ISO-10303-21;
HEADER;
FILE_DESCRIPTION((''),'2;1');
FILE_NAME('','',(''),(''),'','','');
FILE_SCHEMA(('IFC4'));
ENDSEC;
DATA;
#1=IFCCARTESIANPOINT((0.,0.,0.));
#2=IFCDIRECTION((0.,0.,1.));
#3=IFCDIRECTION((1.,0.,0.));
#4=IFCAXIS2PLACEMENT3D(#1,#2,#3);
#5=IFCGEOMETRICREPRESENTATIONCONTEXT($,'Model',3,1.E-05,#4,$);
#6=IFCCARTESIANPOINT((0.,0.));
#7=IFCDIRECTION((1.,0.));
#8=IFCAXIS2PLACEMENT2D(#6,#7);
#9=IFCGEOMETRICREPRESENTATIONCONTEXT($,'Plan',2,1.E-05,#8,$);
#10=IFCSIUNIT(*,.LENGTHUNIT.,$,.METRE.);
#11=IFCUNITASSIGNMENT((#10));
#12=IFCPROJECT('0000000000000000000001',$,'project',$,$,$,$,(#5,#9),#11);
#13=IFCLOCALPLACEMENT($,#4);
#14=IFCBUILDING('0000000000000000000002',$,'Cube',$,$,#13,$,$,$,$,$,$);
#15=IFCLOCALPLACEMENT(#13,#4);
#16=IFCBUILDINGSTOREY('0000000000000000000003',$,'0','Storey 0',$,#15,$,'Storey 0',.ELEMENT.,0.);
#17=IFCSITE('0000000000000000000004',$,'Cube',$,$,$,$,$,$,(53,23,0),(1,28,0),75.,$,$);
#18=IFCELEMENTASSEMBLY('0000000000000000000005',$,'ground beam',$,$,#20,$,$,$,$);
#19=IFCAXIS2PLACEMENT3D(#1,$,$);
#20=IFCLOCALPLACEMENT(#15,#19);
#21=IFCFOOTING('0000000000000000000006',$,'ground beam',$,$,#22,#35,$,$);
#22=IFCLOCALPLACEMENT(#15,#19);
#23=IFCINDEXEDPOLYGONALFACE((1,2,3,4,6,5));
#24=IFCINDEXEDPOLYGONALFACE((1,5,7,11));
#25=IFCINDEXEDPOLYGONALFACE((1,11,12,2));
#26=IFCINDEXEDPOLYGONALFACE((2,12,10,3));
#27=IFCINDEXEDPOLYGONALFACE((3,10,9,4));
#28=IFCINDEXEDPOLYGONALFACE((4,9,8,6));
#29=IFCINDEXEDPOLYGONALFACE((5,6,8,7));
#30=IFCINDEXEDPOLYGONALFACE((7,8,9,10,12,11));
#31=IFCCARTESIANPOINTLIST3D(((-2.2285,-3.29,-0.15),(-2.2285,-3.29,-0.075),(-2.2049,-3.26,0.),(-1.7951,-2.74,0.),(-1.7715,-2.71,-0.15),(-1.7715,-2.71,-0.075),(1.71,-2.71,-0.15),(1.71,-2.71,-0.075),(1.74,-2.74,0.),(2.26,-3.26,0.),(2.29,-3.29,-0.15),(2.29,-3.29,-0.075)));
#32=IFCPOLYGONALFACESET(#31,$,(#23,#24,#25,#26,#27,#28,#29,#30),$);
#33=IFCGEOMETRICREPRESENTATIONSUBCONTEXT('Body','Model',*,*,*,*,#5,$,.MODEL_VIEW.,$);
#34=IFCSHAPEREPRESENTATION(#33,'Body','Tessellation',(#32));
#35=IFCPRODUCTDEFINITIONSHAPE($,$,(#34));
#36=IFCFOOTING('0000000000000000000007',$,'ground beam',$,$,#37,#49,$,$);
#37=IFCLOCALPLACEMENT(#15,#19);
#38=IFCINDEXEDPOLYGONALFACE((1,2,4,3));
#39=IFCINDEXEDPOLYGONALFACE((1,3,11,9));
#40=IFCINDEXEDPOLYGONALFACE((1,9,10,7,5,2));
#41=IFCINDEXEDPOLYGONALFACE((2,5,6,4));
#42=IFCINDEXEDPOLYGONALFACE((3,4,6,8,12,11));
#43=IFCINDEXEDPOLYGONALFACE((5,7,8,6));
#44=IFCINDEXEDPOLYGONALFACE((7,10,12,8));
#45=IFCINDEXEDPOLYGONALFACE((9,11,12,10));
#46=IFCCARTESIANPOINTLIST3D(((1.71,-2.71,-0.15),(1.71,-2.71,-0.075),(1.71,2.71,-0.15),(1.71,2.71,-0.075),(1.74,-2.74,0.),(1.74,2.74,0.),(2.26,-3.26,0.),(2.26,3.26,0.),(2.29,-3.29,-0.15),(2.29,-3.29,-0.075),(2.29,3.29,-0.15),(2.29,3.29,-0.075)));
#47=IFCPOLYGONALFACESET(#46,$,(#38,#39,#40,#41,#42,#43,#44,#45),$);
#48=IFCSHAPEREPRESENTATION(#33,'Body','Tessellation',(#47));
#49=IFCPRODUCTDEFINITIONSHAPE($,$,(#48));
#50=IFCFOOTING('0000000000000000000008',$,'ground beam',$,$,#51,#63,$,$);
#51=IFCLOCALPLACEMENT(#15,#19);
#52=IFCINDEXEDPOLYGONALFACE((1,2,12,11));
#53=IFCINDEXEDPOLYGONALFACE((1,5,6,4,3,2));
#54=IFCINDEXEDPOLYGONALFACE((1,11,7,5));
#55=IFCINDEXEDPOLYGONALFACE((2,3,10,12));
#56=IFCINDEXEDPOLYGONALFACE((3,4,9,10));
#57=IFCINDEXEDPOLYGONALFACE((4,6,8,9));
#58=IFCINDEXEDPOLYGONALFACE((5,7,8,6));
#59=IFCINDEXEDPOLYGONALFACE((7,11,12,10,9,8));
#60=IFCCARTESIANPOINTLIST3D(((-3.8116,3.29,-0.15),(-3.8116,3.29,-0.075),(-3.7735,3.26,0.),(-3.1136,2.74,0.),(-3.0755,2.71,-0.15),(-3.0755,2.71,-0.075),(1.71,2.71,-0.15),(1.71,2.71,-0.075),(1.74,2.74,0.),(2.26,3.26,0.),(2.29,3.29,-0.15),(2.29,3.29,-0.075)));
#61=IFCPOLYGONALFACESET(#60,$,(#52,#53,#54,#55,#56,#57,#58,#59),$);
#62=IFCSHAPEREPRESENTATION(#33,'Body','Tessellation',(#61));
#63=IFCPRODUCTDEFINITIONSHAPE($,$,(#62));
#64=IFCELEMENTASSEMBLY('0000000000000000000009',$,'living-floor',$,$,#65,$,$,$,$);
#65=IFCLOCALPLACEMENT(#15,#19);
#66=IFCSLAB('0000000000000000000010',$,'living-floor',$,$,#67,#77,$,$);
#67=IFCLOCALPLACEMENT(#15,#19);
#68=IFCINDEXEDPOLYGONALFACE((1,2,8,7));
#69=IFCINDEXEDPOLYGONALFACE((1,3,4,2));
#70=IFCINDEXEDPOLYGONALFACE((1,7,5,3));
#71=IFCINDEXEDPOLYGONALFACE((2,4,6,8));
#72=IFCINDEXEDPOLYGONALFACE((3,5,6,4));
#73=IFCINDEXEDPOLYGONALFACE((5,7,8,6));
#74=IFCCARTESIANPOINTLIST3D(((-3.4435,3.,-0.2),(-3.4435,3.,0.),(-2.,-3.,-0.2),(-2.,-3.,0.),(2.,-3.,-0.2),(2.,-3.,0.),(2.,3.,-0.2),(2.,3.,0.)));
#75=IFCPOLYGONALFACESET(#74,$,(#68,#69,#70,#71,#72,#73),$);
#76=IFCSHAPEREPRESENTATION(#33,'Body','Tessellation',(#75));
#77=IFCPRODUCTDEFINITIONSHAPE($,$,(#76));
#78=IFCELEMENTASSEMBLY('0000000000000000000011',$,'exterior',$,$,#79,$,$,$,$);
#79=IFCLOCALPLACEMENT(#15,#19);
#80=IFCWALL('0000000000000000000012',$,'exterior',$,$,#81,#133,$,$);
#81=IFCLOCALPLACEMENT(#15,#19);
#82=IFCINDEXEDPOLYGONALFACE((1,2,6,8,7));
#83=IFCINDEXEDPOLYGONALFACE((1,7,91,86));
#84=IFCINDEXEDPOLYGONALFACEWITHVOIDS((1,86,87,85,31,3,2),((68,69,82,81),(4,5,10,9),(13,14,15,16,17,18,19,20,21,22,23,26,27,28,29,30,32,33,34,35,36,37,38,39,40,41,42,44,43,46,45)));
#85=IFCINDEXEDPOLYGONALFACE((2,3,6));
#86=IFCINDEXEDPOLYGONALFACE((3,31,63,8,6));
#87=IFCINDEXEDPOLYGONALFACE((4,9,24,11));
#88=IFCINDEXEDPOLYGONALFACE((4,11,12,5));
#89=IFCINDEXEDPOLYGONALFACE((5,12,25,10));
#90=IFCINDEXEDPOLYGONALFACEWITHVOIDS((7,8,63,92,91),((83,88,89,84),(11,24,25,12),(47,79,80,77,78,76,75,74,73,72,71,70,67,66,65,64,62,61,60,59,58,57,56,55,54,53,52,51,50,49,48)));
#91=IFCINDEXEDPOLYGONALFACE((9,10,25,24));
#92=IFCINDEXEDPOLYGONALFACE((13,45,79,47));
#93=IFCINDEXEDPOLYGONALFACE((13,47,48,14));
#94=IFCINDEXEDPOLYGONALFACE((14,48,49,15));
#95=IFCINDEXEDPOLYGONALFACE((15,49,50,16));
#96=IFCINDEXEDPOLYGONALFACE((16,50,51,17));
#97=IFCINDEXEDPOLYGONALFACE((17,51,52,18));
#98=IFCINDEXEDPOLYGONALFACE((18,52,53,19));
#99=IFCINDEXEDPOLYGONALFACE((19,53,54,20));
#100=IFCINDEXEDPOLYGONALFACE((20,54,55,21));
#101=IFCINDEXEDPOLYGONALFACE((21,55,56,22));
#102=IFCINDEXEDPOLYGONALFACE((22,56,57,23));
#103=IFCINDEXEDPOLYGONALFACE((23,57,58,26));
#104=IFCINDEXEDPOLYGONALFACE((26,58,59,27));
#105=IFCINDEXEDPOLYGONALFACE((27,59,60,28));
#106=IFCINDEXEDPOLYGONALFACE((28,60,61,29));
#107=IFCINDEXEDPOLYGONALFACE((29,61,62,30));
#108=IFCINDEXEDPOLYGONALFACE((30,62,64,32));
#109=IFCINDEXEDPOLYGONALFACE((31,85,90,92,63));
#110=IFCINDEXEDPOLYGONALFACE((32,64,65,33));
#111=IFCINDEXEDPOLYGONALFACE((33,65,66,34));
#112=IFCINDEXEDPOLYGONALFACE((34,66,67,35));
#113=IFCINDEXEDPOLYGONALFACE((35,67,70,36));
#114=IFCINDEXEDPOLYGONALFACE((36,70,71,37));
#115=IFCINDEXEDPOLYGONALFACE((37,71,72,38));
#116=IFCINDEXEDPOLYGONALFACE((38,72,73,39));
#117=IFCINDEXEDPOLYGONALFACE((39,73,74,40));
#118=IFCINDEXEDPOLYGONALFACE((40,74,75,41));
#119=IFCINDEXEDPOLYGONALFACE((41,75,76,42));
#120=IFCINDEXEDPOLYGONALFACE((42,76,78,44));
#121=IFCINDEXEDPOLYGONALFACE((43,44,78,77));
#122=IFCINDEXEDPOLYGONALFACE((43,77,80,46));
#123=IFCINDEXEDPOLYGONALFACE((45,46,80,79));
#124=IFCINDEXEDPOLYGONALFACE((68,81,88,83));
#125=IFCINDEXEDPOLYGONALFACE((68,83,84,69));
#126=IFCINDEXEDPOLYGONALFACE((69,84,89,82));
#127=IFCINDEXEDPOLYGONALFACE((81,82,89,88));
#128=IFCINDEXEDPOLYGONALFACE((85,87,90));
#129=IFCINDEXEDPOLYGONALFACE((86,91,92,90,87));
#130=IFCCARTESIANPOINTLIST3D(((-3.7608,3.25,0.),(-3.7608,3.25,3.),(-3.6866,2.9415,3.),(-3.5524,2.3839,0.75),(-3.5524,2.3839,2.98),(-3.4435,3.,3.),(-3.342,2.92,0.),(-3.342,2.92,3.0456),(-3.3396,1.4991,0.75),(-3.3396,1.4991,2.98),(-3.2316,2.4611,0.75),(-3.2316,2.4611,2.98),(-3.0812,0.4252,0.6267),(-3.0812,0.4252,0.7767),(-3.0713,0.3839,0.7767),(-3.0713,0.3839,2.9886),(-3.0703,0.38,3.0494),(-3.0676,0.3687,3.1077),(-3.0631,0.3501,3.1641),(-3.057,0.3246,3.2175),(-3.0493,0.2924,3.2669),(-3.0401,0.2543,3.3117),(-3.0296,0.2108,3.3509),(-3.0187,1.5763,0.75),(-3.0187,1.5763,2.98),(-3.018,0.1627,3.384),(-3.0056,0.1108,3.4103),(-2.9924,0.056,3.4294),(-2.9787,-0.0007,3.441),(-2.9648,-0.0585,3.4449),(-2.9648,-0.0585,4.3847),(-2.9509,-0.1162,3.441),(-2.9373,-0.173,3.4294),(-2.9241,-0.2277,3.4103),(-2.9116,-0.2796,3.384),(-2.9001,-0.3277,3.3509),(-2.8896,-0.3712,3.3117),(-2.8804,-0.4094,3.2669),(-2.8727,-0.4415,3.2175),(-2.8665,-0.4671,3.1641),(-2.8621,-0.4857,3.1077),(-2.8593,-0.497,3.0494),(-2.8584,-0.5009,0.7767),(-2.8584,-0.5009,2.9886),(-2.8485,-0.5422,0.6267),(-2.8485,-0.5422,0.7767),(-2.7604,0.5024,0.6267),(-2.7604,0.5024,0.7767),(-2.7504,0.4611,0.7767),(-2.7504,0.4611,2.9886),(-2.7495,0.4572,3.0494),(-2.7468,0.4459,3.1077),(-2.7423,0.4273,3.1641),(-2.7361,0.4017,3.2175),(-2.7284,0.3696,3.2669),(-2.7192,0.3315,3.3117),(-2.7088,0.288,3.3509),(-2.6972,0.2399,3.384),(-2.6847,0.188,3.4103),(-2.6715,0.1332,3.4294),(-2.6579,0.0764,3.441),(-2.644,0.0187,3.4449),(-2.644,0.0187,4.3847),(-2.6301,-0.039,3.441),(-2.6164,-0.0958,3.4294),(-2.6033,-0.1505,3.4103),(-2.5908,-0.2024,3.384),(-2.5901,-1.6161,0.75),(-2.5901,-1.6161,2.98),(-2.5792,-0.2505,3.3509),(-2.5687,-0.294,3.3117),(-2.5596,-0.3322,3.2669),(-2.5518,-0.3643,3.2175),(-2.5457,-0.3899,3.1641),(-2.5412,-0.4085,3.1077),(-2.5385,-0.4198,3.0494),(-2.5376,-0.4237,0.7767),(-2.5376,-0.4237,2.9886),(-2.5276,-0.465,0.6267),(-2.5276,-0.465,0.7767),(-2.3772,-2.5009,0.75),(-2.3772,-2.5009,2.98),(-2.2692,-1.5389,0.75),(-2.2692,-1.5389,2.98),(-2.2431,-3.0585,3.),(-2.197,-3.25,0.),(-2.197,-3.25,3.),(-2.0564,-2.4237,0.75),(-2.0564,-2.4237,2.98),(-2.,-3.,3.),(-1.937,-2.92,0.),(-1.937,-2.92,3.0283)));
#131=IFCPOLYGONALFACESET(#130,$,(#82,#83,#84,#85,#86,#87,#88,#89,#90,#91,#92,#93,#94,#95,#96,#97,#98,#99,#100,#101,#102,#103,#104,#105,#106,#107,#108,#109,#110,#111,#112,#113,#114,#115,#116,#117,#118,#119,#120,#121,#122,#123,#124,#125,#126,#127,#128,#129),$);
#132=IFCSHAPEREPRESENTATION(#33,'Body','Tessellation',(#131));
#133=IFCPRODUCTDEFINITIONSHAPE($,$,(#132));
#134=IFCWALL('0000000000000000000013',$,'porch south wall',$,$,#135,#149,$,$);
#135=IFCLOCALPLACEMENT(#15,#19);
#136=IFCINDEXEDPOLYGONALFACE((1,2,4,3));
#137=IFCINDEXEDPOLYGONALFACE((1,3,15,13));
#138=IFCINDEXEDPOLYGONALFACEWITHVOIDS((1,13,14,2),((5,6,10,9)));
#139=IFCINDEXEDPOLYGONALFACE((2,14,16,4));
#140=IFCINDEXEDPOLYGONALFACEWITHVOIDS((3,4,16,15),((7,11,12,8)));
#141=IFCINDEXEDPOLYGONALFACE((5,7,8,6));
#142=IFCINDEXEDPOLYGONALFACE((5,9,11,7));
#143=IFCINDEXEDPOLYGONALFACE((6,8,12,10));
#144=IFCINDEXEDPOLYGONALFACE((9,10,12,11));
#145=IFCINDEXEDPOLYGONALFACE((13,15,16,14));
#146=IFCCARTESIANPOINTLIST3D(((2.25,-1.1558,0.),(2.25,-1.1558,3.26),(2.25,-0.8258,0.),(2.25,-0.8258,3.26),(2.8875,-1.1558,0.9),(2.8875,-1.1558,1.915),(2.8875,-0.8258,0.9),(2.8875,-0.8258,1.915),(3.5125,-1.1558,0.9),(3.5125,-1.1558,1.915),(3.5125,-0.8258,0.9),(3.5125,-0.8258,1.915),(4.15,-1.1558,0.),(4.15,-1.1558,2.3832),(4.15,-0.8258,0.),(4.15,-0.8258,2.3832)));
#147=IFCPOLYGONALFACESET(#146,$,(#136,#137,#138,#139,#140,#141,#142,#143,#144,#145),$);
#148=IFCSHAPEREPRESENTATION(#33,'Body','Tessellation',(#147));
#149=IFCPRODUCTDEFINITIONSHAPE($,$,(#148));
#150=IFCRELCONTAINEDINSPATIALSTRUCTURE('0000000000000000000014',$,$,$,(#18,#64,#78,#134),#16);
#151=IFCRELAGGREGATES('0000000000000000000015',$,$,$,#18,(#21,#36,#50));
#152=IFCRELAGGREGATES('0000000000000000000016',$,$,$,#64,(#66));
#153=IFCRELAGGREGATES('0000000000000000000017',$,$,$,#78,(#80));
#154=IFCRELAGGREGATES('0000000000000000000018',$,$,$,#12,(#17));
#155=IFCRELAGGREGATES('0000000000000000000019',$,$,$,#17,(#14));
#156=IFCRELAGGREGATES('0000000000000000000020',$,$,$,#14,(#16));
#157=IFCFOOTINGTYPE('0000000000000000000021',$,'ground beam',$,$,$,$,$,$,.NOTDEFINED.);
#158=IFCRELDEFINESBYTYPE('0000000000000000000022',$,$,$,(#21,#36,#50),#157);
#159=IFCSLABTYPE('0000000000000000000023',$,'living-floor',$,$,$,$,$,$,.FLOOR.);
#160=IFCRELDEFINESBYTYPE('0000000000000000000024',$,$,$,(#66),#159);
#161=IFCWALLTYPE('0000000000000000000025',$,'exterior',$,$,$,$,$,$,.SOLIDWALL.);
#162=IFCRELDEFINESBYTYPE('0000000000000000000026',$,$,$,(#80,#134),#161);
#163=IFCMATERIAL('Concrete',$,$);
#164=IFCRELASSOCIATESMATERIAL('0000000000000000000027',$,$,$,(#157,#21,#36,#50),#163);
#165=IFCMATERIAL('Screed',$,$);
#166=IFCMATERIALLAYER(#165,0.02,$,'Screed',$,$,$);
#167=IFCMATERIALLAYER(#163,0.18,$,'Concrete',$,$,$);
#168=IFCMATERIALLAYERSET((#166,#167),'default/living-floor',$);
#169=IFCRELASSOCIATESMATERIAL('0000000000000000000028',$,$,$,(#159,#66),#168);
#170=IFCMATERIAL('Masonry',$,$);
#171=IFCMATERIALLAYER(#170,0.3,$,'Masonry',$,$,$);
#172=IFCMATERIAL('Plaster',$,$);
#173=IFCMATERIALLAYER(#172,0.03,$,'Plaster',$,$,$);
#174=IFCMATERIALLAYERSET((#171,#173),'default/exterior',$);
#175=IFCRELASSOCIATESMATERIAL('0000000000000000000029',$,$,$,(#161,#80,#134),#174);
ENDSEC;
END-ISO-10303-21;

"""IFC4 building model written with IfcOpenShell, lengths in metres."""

from ifc_helpers import new_model, si_unit, frame, origin, origin_with_axes, origin_2d_with_axis, place, context, subcontext, project, spatial, polyline, indexed_curve, outline, extrude, clip, halfspace, bounded_halfspace, material, layer, layer_set, layer_usage, material_profile, profile_set, profile_usage, type_object, element, aggregate, save


model = new_model("IFC4")

# Units and contexts
model_context = context("Model", 3, precision=1e-05, world=origin_with_axes())
plan_context = context("Plan", 2, precision=1e-05, world=origin_2d_with_axis())
body_context_1 = subcontext(model_context, "Body", "Model", "MODEL_VIEW")
ifc_project = project(units=[si_unit("LENGTHUNIT", "METRE")], contexts=[model_context, plan_context])

# Site, building, storey
site = spatial("IfcSite", under=ifc_project, Name="Cube", RefLatitude=(53, 23, 0), RefLongitude=(1, 28, 0), RefElevation=75.0)
building_placement = place(None, origin_with_axes())
building = spatial("IfcBuilding", under=site, at=building_placement, Name="Cube")
storey_placement = place(building_placement, origin_with_axes())
storey = spatial("IfcBuildingStorey", under=building, at=storey_placement, Name="0", Description="Storey 0", LongName="Storey 0", CompositionType="ELEMENT", Elevation=0.0)

# Element assembly, footings
assembly_1_placement = place(storey_placement, origin_with_axes())
assembly_1 = element("IfcElementAssembly", 1, at=assembly_1_placement, inside=storey, Name="ground beam")
ifc_material_1 = material(Name="Concrete")
ifc_material_profile = material_profile(ifc_material_1, outline(polyline([(-0.26, 0.0), (-0.29, -0.075), (-0.29, -0.15), (0.29, -0.15), (0.29, -0.075), (0.26, 0.0), (-0.26, 0.0)])))
ifc_profile_set = profile_set([ifc_material_profile])
ifc_profile_usage_1 = profile_usage(ifc_profile_set)
footing_type = type_object("IfcFootingType", Name="ground beam", PredefinedType="NOTDEFINED", material=ifc_profile_set)
footing_1_placement = place(assembly_1_placement, frame((3.0, -3.0, 0.0), z_axis=(-1.0, 0.0, 0.0), x_axis=(0.0, -1.0, 0.0)))
footing_1 = element("IfcFooting", 2, at=footing_1_placement, type_object=footing_type, material=ifc_profile_usage_1, Name="ground beam", context=body_context_1, shape_type="Clipping", body=[
    clip(clip(extrude(outline(polyline([(-0.26, 0.0), (-0.29, -0.075), (-0.29, -0.15), (0.29, -0.15), (0.29, -0.075), (0.26, 0.0), (-0.26, 0.0)])), origin_with_axes(), (0.0, 0.0, 1.0), 6.0), halfspace(frame((0.0, 0.0, 1.0), z_axis=(-0.707107, 0.0, -0.707107), x_axis=(0.0, 1.0, 0.0)), False)), halfspace(frame((0.0, 0.0, 5.0), z_axis=(-0.618904, 0.0, 0.785467), x_axis=(0.0, 1.0, 0.0)), False)),
])
ifc_profile_usage_2 = profile_usage(ifc_profile_set)
footing_2_placement = place(assembly_1_placement, frame((2.0, 4.0, 0.0), z_axis=(0.0, -1.0, 0.0), x_axis=(1.0, 0.0, 0.0)))
footing_2 = element("IfcFooting", 3, at=footing_2_placement, type_object=footing_type, material=ifc_profile_usage_2, Name="ground beam", context=body_context_1, shape_type="Clipping", body=[
    clip(clip(extrude(outline(polyline([(-0.26, 0.0), (-0.29, -0.075), (-0.29, -0.15), (0.29, -0.15), (0.29, -0.075), (0.26, 0.0), (-0.26, 0.0)])), origin_with_axes(), (0.0, 0.0, 1.0), 8.0), halfspace(frame((0.0, 0.0, 1.0), z_axis=(-0.707107, 0.0, -0.707107), x_axis=(0.0, 1.0, 0.0)), False)), halfspace(frame((0.0, 0.0, 7.0), z_axis=(-0.707107, 0.0, 0.707107), x_axis=(0.0, 1.0, 0.0)), False)),
])
ifc_profile_usage_3 = profile_usage(ifc_profile_set)
footing_3_placement = place(assembly_1_placement, frame((-4.4435, 3.0, 0.0), z_axis=(1.0, 0.0, 0.0), x_axis=(0.0, 1.0, 0.0)))
footing_3 = element("IfcFooting", 4, at=footing_3_placement, type_object=footing_type, material=ifc_profile_usage_3, Name="ground beam", context=body_context_1, shape_type="Clipping", body=[
    clip(clip(extrude(outline(polyline([(-0.26, 0.0), (-0.29, -0.075), (-0.29, -0.15), (0.29, -0.15), (0.29, -0.075), (0.26, 0.0), (-0.26, 0.0)])), origin_with_axes(), (0.0, 0.0, 1.0), 7.4435), halfspace(frame((0.0, 0.0, 1.0), z_axis=(-0.785467, 0.0, -0.618904), x_axis=(0.0, 1.0, 0.0)), False)), halfspace(frame((0.0, 0.0, 6.4435), z_axis=(-0.707107, 0.0, 0.707107), x_axis=(0.0, 1.0, 0.0)), False)),
])
aggregate(assembly_1, [footing_1, footing_2, footing_3])

# Element assembly, slab
assembly_2_placement = place(storey_placement, origin_with_axes())
assembly_2 = element("IfcElementAssembly", 5, at=assembly_2_placement, inside=storey, Name="living-floor")
ifc_material_2 = material(Name="Screed")
ifc_layer_1 = layer(ifc_material_2, 0.02, Name="Screed")
ifc_layer_2 = layer(ifc_material_1, 0.18, Name="Concrete")
ifc_layer_set_1 = layer_set([ifc_layer_1, ifc_layer_2], Name="default/living-floor")
ifc_layer_usage_1 = layer_usage(ifc_layer_set_1, "AXIS3", "POSITIVE", 0.0)
slab_type = type_object("IfcSlabType", Name="living-floor", PredefinedType="FLOOR", material=ifc_layer_set_1)
slab_placement = place(assembly_2_placement, frame((2.0, 3.0, -0.2), z_axis=(0.0, 0.0, -1.0), x_axis=(0.0, 1.0, 0.0)))
slab = element("IfcSlab", 6, at=slab_placement, type_object=slab_type, material=ifc_layer_usage_1, Name="living-floor", context=body_context_1, shape_type="SweptSolid", body=[
    extrude(outline(polyline([(0.0, 0.0), (-6.0, 0.0), (-6.0, -4.0), (0.0, -5.4435), (0.0, 0.0)])), origin(), (0.0, 0.0, -1.0), 0.2),
])
aggregate(assembly_2, [slab])

# Element assembly, wall, openings
assembly_3_placement = place(storey_placement, frame((-3.4435, 3.0, 0.0), z_axis=(0.0, 0.0, 1.0), x_axis=(0.233915, -0.972257, 0.0)))
assembly_3 = element("IfcElementAssembly", 7, at=assembly_3_placement, inside=storey, Name="exterior")
ifc_material_3 = material(Name="Masonry")
ifc_layer_3 = layer(ifc_material_3, 0.3, Name="Masonry")
ifc_material_4 = material(Name="Plaster")
ifc_layer_4 = layer(ifc_material_4, 0.03, Name="Plaster")
ifc_layer_set_2 = layer_set([ifc_layer_3, ifc_layer_4], Name="default/exterior")
ifc_layer_usage_2 = layer_usage(ifc_layer_set_2, "AXIS2", "POSITIVE", -0.25)
wall_type = type_object("IfcWallType", Name="exterior", PredefinedType="SOLIDWALL", material=ifc_layer_set_2)
wall_1_placement = place(assembly_3_placement, frame((0.0, 0.0, 0.0), z_axis=(0.0, 0.0, 1.0), x_axis=(1.0, 0.0, 0.0)))
wall_1 = element("IfcWall", 8, at=wall_1_placement, type_object=wall_type, material=ifc_layer_usage_2, Name="exterior", context=body_context_1, shape_type="Clipping", body=[
    clip(clip(clip(clip(extrude(outline(polyline([(0.1015, 0.08), (-0.3173, -0.25), (6.3682, -0.25), (6.1082, 0.08), (0.1015, 0.08)])), origin(), (0.0, 0.0, 1.0), 4.385), bounded_halfspace(frame((6.1712, 0.0, 3.0), z_axis=(0.409415, 0.0, 0.912348), x_axis=(0.0, -1.0, 0.0)), False, origin(), polyline([(6.1712, -1.0), (3.0856, -1.0), (3.0856, 1.0), (6.1712, 1.0), (6.1712, -1.0)]))), bounded_halfspace(frame((6.1712, 0.0, 3.0), z_axis=(0.0, 0.0, 1.0), x_axis=(0.0, 1.0, 0.0)), False, origin(), polyline([(6.1712, 1.0), (7.1712, 1.0), (7.1712, -1.0), (6.1712, -1.0), (6.1712, 1.0)]))), bounded_halfspace(frame((3.0856, 0.0, 4.3847), z_axis=(-0.409415, 0.0, 0.912348), x_axis=(0.0, -1.0, 0.0)), False, origin(), polyline([(3.0856, -1.0), (0.0, -1.0), (0.0, 1.0), (3.0856, 1.0), (3.0856, -1.0)]))), bounded_halfspace(frame((0.0, 0.0, 3.0), z_axis=(0.0, 0.0, 1.0), x_axis=(0.0, -1.0, 0.0)), False, origin(), polyline([(0.0, -1.0), (-1.0, -1.0), (-1.0, 1.0), (0.0, 1.0), (0.0, -1.0)]))),
])
opening_1_placement = place(wall_1_placement, frame((0.5735, -0.25, 0.75), z_axis=(0.0, 0.0, 1.0), x_axis=(1.0, 0.0, 0.0)))
element("IfcOpeningElement", 9, at=opening_1_placement, cuts=wall_1, PredefinedType="OPENING", context=body_context_1, shape_type="SweptSolid", body=[
    extrude(outline(polyline([(0.0, -0.02), (0.91, -0.02), (0.91, 0.35), (0.0, 0.35), (0.0, -0.02)])), origin(), (0.0, 0.0, 1.0), 2.23),
])
opening_2_placement = place(wall_1_placement, frame((2.6306, -0.25, 0.75), z_axis=(0.0, 0.0, 1.0), x_axis=(1.0, 0.0, 0.0)))
element("IfcOpeningElement", 10, at=opening_2_placement, cuts=wall_1, PredefinedType="OPENING", context=body_context_1, shape_type="SweptSolid", body=[
    extrude(outline(polyline([(0.1333, 2.5617), (0.1781, 2.6009), (0.2275, 2.634), (0.2809, 2.6603), (0.3373, 2.6794), (0.3956, 2.691), (0.455, 2.6949), (0.5144, 2.691), (0.5727, 2.6794), (0.6291, 2.6603), (0.6825, 2.634), (0.7319, 2.6009), (0.7767, 2.5617), (0.8159, 2.5169), (0.849, 2.4675), (0.8753, 2.4141), (0.8944, 2.3577), (0.906, 2.2994), (0.91, 2.2386), (0.91, 2.2069), (0.91, 0.0267), (0.9525, 0.0267), (0.9525, -0.1233), (-0.0425, -0.1233), (-0.0425, 0.0267), (0.0, 0.0267), (0.0, 2.2069), (0.0, 2.2386), (0.004, 2.2994), (0.0156, 2.3577), (0.0347, 2.4141), (0.061, 2.4675), (0.0941, 2.5169), (0.1333, 2.5617)])), frame((0.0, -0.02, 0.0), z_axis=(0.0, -1.0, 0.0), x_axis=(1.0, 0.0, 0.0)), (0.0, 0.0, -1.0), 0.37),
])
opening_3_placement = place(wall_1_placement, frame((4.6877, -0.25, 0.75), z_axis=(0.0, 0.0, 1.0), x_axis=(1.0, 0.0, 0.0)))
element("IfcOpeningElement", 11, at=opening_3_placement, cuts=wall_1, PredefinedType="OPENING", context=body_context_1, shape_type="SweptSolid", body=[
    extrude(outline(polyline([(0.0, -0.02), (0.91, -0.02), (0.91, 0.35), (0.0, 0.35), (0.0, -0.02)])), origin(), (0.0, 0.0, 1.0), 2.23),
])
aggregate(assembly_3, [wall_1])

# Wall, opening
ifc_layer_usage_3 = layer_usage(ifc_layer_set_2, "AXIS2", "POSITIVE", 0.0)
wall_2_placement = place(storey_placement, frame((2.25, -1.1558, 0.0), z_axis=(0.0, 0.0, 1.0), x_axis=(1.0, 0.0, 0.0)))
wall_2 = element("IfcWall", 12, at=wall_2_placement, inside=storey, type_object=wall_type, material=ifc_layer_usage_3, Name="porch south wall", context=body_context_1, shape_type="Clipping", body=[
    clip(extrude(outline(indexed_curve([(0.0, 0.0), (0.0, 0.33), (1.9, 0.33), (1.9, 0.0), (0.0, 0.0)], self_intersect=False)), origin_with_axes(), (0.0, 0.0, 1.0), 3.5), halfspace(frame((0.0, 0.0, 3.26), z_axis=(0.419, 0.0, 0.908), x_axis=(0.0, 1.0, 0.0)), False)),
])
opening_4_placement = place(wall_2_placement, frame((0.6375, -0.0002, 0.9), z_axis=(0.0, 0.0, 1.0), x_axis=(1.0, 0.0, 0.0)))
element("IfcOpeningElement", 13, at=opening_4_placement, cuts=wall_2, context=body_context_1, shape_type="SweptSolid", body=[
    extrude(outline(indexed_curve([(0.0, 0.0), (0.0, 0.5), (0.625, 0.5), (0.625, 0.0), (0.0, 0.0)], self_intersect=False)), origin_with_axes(), (0.0, 0.0, 1.0), 1.015),
])

save(model, "model.ifc")
